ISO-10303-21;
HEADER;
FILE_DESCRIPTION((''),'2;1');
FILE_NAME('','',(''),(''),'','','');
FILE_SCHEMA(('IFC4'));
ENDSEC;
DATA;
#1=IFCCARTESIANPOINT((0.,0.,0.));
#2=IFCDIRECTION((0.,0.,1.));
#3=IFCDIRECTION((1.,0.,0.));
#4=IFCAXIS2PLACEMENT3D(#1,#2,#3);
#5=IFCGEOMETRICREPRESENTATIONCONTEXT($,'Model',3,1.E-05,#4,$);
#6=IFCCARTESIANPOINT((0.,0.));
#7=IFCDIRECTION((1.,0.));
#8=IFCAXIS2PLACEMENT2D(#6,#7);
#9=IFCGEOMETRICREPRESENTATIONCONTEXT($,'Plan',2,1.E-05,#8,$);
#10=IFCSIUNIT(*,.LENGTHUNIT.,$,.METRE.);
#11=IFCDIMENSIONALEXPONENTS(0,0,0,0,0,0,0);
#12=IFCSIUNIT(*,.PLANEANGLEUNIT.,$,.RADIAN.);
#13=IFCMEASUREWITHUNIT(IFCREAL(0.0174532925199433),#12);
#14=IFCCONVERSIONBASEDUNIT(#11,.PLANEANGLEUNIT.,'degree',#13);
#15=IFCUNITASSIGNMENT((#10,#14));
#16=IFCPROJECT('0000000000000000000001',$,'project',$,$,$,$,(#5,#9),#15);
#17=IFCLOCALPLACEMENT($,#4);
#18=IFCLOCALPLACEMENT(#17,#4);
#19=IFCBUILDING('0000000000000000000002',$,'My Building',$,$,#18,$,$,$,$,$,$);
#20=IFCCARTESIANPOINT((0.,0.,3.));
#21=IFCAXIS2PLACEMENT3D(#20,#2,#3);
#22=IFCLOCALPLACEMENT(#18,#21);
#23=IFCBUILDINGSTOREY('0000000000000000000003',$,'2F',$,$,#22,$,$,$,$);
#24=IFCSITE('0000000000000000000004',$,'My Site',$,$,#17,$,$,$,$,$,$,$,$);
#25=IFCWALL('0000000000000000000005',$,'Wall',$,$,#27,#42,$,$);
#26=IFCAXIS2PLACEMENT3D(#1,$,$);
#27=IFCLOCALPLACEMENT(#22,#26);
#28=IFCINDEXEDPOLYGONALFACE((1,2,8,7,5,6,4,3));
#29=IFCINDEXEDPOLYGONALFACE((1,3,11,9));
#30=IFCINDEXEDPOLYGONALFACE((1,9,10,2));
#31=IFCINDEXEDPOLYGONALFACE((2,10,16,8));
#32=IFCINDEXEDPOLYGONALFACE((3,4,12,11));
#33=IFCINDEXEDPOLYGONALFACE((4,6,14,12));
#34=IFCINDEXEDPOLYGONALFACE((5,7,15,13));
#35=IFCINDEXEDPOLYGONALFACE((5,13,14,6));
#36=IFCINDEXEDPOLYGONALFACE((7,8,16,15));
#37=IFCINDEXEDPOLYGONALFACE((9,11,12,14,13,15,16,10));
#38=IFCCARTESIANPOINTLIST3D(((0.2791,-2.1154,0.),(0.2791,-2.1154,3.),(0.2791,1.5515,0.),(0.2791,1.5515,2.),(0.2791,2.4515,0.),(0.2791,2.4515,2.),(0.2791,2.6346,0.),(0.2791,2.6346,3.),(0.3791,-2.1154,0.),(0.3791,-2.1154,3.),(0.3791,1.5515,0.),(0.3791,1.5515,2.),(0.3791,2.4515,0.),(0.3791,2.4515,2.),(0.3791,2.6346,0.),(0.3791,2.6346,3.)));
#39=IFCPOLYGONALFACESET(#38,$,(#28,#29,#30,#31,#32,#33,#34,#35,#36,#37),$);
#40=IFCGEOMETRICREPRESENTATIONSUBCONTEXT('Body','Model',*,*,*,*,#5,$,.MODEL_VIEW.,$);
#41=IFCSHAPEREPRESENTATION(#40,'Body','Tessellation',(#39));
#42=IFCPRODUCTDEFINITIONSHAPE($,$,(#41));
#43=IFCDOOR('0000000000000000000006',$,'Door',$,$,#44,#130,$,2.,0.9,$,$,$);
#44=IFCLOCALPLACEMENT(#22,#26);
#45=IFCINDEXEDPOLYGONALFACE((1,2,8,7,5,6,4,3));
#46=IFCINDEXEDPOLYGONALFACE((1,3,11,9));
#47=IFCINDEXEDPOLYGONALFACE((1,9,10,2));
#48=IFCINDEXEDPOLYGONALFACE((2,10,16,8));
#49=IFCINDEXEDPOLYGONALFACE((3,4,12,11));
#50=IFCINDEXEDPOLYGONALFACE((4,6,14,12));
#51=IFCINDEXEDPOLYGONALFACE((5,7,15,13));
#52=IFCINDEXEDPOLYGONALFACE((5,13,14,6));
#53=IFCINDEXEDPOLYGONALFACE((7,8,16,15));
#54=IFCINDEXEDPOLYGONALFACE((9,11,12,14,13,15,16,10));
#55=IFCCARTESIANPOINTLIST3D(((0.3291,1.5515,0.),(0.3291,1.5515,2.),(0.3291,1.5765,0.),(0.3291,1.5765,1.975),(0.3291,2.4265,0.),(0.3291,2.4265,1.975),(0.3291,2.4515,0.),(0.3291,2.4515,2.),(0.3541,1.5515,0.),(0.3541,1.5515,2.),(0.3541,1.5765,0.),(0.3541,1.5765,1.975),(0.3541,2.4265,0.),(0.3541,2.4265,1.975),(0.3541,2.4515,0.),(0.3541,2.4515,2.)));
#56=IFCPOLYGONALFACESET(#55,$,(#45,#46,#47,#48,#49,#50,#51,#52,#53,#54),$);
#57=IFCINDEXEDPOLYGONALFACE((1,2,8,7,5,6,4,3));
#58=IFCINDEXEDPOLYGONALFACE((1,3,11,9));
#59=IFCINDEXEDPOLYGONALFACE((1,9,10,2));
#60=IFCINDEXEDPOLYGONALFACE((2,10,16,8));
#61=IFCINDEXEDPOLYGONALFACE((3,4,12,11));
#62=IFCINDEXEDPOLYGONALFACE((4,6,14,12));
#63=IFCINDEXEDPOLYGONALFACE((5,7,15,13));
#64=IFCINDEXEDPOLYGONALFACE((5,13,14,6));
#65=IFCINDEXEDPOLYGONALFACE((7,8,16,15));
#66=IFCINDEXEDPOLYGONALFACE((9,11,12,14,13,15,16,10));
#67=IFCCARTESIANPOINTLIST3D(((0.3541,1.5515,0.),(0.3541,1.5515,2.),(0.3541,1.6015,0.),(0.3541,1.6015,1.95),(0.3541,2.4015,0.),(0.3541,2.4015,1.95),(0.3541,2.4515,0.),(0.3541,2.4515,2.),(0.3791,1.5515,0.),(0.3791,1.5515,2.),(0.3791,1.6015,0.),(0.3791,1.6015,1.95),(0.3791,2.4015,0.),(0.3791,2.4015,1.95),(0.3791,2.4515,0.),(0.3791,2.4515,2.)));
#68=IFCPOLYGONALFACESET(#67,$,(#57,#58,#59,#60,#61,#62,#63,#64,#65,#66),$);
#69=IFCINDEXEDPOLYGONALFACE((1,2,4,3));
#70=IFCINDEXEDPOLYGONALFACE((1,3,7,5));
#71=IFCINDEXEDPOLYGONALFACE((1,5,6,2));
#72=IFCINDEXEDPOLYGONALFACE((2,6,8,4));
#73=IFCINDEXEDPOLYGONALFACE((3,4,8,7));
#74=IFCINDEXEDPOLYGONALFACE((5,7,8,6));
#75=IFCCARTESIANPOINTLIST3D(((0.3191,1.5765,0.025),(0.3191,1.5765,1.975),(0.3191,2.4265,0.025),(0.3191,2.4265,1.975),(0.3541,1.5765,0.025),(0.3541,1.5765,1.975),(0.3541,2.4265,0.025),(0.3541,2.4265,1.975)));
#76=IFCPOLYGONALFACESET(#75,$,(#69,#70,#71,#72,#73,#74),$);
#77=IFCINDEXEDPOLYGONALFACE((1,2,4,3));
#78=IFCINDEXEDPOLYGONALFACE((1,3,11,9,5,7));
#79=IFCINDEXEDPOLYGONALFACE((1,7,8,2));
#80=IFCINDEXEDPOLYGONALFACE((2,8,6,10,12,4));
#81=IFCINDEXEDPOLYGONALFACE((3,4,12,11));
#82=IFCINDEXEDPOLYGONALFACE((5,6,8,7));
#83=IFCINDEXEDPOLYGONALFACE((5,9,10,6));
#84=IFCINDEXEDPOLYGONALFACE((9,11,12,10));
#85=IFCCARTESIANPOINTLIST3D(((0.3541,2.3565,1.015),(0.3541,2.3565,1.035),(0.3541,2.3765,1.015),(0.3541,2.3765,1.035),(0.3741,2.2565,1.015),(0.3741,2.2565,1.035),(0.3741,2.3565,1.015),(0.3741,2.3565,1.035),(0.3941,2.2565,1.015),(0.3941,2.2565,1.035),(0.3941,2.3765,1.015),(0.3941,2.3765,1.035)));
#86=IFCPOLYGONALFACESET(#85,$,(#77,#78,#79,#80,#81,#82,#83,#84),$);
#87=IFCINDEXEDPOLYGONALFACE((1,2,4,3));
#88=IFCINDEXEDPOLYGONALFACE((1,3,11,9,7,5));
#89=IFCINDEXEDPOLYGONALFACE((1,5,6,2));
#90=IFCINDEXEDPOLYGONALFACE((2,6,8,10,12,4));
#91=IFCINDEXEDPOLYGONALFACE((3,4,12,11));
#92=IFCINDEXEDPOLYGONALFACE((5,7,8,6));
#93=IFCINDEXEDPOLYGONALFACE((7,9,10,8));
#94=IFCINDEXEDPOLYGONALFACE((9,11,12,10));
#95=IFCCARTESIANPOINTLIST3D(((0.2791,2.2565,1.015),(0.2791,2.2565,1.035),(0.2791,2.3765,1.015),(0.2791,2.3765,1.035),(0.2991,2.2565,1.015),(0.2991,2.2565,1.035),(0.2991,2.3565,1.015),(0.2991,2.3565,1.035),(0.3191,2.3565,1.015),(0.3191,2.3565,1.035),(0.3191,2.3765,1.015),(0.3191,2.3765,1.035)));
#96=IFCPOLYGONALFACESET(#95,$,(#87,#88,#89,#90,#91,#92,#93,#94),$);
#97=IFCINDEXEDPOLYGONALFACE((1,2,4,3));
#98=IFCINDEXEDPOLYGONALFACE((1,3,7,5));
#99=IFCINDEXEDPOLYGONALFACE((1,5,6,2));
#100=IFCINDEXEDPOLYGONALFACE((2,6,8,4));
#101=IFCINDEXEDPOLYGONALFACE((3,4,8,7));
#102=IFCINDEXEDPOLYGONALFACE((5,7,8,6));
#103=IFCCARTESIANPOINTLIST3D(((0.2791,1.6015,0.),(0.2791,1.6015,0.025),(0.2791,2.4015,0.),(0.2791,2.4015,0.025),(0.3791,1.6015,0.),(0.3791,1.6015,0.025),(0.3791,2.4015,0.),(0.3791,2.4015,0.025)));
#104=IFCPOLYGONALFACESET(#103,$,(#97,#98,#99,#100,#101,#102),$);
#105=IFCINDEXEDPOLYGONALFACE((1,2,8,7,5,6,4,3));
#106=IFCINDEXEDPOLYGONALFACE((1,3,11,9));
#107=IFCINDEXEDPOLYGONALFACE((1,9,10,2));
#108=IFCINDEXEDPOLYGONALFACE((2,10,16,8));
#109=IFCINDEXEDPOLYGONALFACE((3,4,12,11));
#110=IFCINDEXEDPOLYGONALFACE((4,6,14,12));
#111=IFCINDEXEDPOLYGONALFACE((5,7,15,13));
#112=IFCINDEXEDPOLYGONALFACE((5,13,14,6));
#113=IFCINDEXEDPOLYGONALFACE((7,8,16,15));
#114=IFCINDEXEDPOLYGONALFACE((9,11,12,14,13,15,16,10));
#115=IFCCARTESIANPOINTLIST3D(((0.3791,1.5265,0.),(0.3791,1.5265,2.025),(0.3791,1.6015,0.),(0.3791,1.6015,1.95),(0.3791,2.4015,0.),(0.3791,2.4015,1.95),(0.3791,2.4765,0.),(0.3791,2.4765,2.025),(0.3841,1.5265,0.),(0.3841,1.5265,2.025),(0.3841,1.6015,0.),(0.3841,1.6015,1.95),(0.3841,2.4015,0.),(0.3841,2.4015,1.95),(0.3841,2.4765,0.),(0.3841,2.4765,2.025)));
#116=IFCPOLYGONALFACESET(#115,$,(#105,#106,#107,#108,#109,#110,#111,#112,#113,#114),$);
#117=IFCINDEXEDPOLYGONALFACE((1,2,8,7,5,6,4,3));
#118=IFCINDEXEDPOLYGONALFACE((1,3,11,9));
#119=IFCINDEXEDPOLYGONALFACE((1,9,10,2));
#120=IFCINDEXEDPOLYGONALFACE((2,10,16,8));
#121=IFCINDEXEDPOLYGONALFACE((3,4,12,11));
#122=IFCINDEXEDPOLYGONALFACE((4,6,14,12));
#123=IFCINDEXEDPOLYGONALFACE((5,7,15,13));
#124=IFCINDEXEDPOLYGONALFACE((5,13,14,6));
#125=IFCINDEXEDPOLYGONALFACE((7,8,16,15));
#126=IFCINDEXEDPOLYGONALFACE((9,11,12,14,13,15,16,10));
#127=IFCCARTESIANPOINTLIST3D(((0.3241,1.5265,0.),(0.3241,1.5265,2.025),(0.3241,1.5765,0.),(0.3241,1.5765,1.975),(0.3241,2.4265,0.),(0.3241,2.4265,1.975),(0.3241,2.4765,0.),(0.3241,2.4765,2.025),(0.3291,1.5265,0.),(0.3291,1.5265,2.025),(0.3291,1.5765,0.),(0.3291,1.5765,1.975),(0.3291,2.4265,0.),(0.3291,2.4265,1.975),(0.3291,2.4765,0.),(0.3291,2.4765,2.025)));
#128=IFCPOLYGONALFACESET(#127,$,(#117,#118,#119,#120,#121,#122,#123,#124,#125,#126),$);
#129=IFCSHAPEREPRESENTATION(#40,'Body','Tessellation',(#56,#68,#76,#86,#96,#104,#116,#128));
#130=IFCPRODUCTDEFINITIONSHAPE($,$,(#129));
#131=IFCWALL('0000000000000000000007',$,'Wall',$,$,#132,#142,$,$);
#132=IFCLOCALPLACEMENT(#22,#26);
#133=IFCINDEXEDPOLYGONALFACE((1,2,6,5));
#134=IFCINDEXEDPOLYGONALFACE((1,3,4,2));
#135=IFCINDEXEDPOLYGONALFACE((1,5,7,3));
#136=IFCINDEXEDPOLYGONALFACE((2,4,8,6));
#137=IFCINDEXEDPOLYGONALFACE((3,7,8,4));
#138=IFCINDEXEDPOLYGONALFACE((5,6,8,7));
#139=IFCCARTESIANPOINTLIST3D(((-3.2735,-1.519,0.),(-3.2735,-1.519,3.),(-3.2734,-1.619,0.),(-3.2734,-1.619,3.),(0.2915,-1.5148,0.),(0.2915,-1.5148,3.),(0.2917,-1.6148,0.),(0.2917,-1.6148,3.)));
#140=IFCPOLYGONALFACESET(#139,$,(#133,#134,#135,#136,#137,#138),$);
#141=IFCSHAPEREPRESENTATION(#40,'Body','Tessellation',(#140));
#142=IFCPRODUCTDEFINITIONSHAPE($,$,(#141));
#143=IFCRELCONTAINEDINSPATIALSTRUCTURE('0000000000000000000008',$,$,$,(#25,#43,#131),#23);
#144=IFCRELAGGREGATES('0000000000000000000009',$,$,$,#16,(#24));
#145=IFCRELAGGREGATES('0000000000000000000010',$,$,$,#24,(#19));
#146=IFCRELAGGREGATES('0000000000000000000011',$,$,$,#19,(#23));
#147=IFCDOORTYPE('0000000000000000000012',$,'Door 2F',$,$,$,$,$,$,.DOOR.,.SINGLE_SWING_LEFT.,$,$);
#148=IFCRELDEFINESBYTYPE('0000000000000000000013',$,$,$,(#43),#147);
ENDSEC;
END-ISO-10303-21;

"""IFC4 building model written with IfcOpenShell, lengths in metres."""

from ifc_helpers import new_model, entity, si_unit, converted_unit, frame, origin_with_axes, origin_2d_with_axis, place, context, subcontext, project, spatial, line, indexed_curve, outline, extrude, shape, source, transform, mapped, type_object, type_shapes, element, fill, save


model = new_model("IFC4")

# Units and contexts
model_context = context("Model", 3, precision=1e-05, world=origin_with_axes())
plan_context = context("Plan", 2, precision=1e-05, world=origin_2d_with_axis())
body_context_1 = subcontext(model_context, "Body", "Model", "MODEL_VIEW")
body_context_2 = subcontext(plan_context, "Body", "Plan", "PLAN_VIEW")
ifc_project = project(units=[si_unit("LENGTHUNIT", "METRE"), converted_unit("PLANEANGLEUNIT", "degree", entity("IfcReal", 0.0174532925199433), si_unit("PLANEANGLEUNIT", "RADIAN"), dimensions=[0, 0, 0, 0, 0, 0, 0])], contexts=[model_context, plan_context])

# Site, building, storey
site_placement = place(None, origin_with_axes())
site = spatial("IfcSite", under=ifc_project, at=site_placement, Name="My Site")
building_placement = place(site_placement, origin_with_axes())
building = spatial("IfcBuilding", under=site, at=building_placement, Name="My Building")
storey_placement = place(building_placement, frame((0.0, 0.0, 3.0), z_axis=(0.0, 0.0, 1.0), x_axis=(1.0, 0.0, 0.0)))
storey = spatial("IfcBuildingStorey", under=building, at=storey_placement, Name="2F")

# Shared definitions
shared_shape_1 = source(origin_with_axes(), body_context_1, "Body", "SweptSolid", [
    extrude(outline(indexed_curve([(0.0, 0.0), (0.9, 0.0), (0.9, 2.0), (0.0, 2.0)], segments=[line(1, 2, 3, 4, 1)])), frame((0.0, -0.6, 0.0), z_axis=(0.0, -1.0, 0.0), x_axis=(1.0, 0.0, 0.0)), (0.0, 0.0, -1.0), 1.2),
])
door_type = type_object("IfcDoorType", Name="Door 2F", OperationType="SINGLE_SWING_LEFT", PredefinedType="DOOR")
shared_shape_2 = source(origin_with_axes(), body_context_1, "Body", "SweptSolid", [
    extrude(outline(indexed_curve([(0.0, 0.0), (0.0, 2.0), (0.9, 2.0), (0.9, 0.0), (0.875, 0.0), (0.875, 1.975), (0.025, 1.975), (0.025, 0.0)], segments=[line(1, 2, 3, 4, 5, 6, 7, 8, 1)])), frame((0.0, 0.025, 0.0), z_axis=(0.0, -1.0, 0.0), x_axis=(1.0, 0.0, 0.0)), (0.0, 0.0, -1.0), 0.025),
    extrude(outline(indexed_curve([(0.0, 0.0), (0.0, 2.0), (0.9, 2.0), (0.9, 0.0), (0.85, 0.0), (0.85, 1.95), (0.05, 1.95), (0.05, 0.0)], segments=[line(1, 2, 3, 4, 5, 6, 7, 8, 1)])), frame((0.0, 0.0, 0.0), z_axis=(0.0, -1.0, 0.0), x_axis=(1.0, 0.0, 0.0)), (0.0, 0.0, -1.0), 0.025),
    extrude(outline(indexed_curve([(0.0, 0.0), (0.85, 0.0), (0.85, 0.035), (0.0, 0.035)], segments=[line(1, 2, 3, 4, 1)])), frame((0.025, 0.025, 0.025), z_axis=(0.0, 0.0, 1.0), x_axis=(1.0, 0.0, 0.0)), (0.0, 0.0, 1.0), 1.95),
    extrude(outline(indexed_curve([(0.0, 0.0), (0.0, -0.04), (-0.12, -0.04), (-0.12, -0.02), (-0.02, -0.02), (-0.02, 0.0)], segments=[line(1, 2, 3, 4, 5, 6, 1)])), frame((0.825, 0.025, 1.015), z_axis=(0.0, 0.0, 1.0), x_axis=(1.0, 0.0, 0.0)), (0.0, 0.0, 1.0), 0.02),
    extrude(outline(indexed_curve([(0.0, 0.0), (0.0, 0.04), (-0.12, 0.04), (-0.12, 0.02), (-0.02, 0.02), (-0.02, 0.0)], segments=[line(1, 2, 3, 4, 5, 6, 1)])), frame((0.825, 0.06, 1.015), z_axis=(0.0, 0.0, 1.0), x_axis=(1.0, 0.0, 0.0)), (0.0, 0.0, 1.0), 0.02),
    extrude(outline(indexed_curve([(0.0, 0.0), (0.8, 0.0), (0.8, 0.1), (0.0, 0.1)], segments=[line(1, 2, 3, 4, 1)])), frame((0.05, 0.0, 0.0), z_axis=(0.0, 0.0, 1.0), x_axis=(1.0, 0.0, 0.0)), (0.0, 0.0, 1.0), 0.025),
    extrude(outline(indexed_curve([(0.0, 0.0), (0.0, 2.025), (0.95, 2.025), (0.95, 0.0), (0.875, 0.0), (0.875, 1.95), (0.075, 1.95), (0.075, 0.0)], segments=[line(1, 2, 3, 4, 5, 6, 7, 8, 1)])), frame((-0.025, -0.005, 0.0), z_axis=(0.0, -1.0, 0.0), x_axis=(1.0, 0.0, 0.0)), (0.0, 0.0, -1.0), 0.005),
    extrude(outline(indexed_curve([(0.0, 0.0), (0.0, 2.025), (0.95, 2.025), (0.95, 0.0), (0.9, 0.0), (0.9, 1.975), (0.05, 1.975), (0.05, 0.0)], segments=[line(1, 2, 3, 4, 5, 6, 7, 8, 1)])), frame((-0.025, 0.05, 0.0), z_axis=(0.0, -1.0, 0.0), x_axis=(1.0, 0.0, 0.0)), (0.0, 0.0, -1.0), 0.005),
])
shared_shape_3 = source(origin_with_axes(), body_context_2, "Body", "Curve2D", [
    entity("IfcIndexedPolyCurve", entity("IfcCartesianPointList2D", [[0.0, 0.0], [0.0, 0.05], [0.025, 0.05], [0.025, 0.025], [0.05, 0.025], [0.05, 0.0]]), [entity("IfcLineIndex", [1, 2, 3, 4, 5, 6, 1])]),
    entity("IfcIndexedPolyCurve", entity("IfcCartesianPointList2D", [[0.9, 0.0], [0.9, 0.05], [0.875, 0.05], [0.875, 0.025], [0.85, 0.025], [0.85, 0.0]]), [entity("IfcLineIndex", [1, 2, 3, 4, 5, 6, 1])]),
    entity("IfcTrimmedCurve", entity("IfcEllipse", entity("IfcAxis2Placement2D", entity("IfcCartesianPoint", [0.06, 0.05]), entity("IfcDirection", [1.0, 0.0])), 0.815, 0.85), [entity("IfcCartesianPoint", [0.875, 0.05])], [entity("IfcCartesianPoint", [0.06, 0.9])], True, "CARTESIAN"),
    entity("IfcIndexedPolyCurve", entity("IfcCartesianPointList2D", [[0.025, 0.05], [0.06, 0.05], [0.06, 0.9], [0.025, 0.9]]), [entity("IfcLineIndex", [1, 2, 3, 4, 1])]),
])
type_shapes(door_type, [shared_shape_2, shared_shape_3])

# Wall, opening, door
wall_1_placement = place(storey_placement, frame((0.3791, -2.1154, 0.0), z_axis=(0.0, 0.0, 1.0), x_axis=(0.0, 1.0, 0.0)))
wall_1 = element("IfcWall", 1, at=wall_1_placement, inside=storey, Name="Wall", context=body_context_1, shape_type="SweptSolid", body=[
    extrude(outline(indexed_curve([(0.0, 0.0), (0.0, 0.1), (4.75, 0.1), (4.75, 0.0)], segments=[line(1, 2, 3, 4, 1)])), origin_with_axes(), (0.0, 0.0, 1.0), 3.0),
])
opening_1_placement = place(wall_1_placement, frame((3.6669, 0.0, 0.0), z_axis=(0.0, 0.0, 1.0), x_axis=(1.0, 0.0, 0.0)))
opening_1 = element("IfcOpeningElement", 2, at=opening_1_placement, cuts=wall_1, PredefinedType="OPENING", context=body_context_1, shape_type="MappedRepresentation", body=[
    mapped(shared_shape_1, transform((0.0, 0.0, 0.0), x_axis=(1.0, 0.0, 0.0), y_axis=(0.0, 1.0, 0.0), z_axis=(0.0, 0.0, 1.0), scale=1.0)),
])
door_1_placement = place(opening_1_placement, frame((0.0, 0.0, 0.0), z_axis=(0.0, 0.0, 1.0), x_axis=(1.0, 0.0, 0.0)))
door_1 = element("IfcDoor", 3, at=door_1_placement, inside=storey, type_object=door_type, Name="Door", OverallHeight=2.0, OverallWidth=0.9, shapes=[
    shape(body_context_1, "Body", "MappedRepresentation", [mapped(shared_shape_2, transform((0.0, 0.0, 0.0), x_axis=(1.0, 0.0, 0.0), y_axis=(0.0, 1.0, 0.0), z_axis=(0.0, 0.0, 1.0), scale=1.0))]),
    shape(body_context_2, "Body", "MappedRepresentation", [mapped(shared_shape_3, transform((0.0, 0.0, 0.0), x_axis=(1.0, 0.0, 0.0), y_axis=(0.0, 1.0, 0.0), z_axis=(0.0, 0.0, 1.0), scale=1.0))]),
])
fill(opening_1, door_1)

# Wall
wall_2_placement = place(storey_placement, frame((-3.2734, -1.619, 0.0), z_axis=(0.0, 0.0, 1.0), x_axis=(0.999999, 0.001166, 0.0)))
element("IfcWall", 4, at=wall_2_placement, inside=storey, Name="Wall", context=body_context_1, shape_type="SweptSolid", body=[
    extrude(outline(indexed_curve([(0.0, 0.0), (0.0, 0.1), (3.5651, 0.1), (3.5651, 0.0)], segments=[line(1, 2, 3, 4, 1)])), origin_with_axes(), (0.0, 0.0, 1.0), 3.0),
])

save(model, "model.ifc")
